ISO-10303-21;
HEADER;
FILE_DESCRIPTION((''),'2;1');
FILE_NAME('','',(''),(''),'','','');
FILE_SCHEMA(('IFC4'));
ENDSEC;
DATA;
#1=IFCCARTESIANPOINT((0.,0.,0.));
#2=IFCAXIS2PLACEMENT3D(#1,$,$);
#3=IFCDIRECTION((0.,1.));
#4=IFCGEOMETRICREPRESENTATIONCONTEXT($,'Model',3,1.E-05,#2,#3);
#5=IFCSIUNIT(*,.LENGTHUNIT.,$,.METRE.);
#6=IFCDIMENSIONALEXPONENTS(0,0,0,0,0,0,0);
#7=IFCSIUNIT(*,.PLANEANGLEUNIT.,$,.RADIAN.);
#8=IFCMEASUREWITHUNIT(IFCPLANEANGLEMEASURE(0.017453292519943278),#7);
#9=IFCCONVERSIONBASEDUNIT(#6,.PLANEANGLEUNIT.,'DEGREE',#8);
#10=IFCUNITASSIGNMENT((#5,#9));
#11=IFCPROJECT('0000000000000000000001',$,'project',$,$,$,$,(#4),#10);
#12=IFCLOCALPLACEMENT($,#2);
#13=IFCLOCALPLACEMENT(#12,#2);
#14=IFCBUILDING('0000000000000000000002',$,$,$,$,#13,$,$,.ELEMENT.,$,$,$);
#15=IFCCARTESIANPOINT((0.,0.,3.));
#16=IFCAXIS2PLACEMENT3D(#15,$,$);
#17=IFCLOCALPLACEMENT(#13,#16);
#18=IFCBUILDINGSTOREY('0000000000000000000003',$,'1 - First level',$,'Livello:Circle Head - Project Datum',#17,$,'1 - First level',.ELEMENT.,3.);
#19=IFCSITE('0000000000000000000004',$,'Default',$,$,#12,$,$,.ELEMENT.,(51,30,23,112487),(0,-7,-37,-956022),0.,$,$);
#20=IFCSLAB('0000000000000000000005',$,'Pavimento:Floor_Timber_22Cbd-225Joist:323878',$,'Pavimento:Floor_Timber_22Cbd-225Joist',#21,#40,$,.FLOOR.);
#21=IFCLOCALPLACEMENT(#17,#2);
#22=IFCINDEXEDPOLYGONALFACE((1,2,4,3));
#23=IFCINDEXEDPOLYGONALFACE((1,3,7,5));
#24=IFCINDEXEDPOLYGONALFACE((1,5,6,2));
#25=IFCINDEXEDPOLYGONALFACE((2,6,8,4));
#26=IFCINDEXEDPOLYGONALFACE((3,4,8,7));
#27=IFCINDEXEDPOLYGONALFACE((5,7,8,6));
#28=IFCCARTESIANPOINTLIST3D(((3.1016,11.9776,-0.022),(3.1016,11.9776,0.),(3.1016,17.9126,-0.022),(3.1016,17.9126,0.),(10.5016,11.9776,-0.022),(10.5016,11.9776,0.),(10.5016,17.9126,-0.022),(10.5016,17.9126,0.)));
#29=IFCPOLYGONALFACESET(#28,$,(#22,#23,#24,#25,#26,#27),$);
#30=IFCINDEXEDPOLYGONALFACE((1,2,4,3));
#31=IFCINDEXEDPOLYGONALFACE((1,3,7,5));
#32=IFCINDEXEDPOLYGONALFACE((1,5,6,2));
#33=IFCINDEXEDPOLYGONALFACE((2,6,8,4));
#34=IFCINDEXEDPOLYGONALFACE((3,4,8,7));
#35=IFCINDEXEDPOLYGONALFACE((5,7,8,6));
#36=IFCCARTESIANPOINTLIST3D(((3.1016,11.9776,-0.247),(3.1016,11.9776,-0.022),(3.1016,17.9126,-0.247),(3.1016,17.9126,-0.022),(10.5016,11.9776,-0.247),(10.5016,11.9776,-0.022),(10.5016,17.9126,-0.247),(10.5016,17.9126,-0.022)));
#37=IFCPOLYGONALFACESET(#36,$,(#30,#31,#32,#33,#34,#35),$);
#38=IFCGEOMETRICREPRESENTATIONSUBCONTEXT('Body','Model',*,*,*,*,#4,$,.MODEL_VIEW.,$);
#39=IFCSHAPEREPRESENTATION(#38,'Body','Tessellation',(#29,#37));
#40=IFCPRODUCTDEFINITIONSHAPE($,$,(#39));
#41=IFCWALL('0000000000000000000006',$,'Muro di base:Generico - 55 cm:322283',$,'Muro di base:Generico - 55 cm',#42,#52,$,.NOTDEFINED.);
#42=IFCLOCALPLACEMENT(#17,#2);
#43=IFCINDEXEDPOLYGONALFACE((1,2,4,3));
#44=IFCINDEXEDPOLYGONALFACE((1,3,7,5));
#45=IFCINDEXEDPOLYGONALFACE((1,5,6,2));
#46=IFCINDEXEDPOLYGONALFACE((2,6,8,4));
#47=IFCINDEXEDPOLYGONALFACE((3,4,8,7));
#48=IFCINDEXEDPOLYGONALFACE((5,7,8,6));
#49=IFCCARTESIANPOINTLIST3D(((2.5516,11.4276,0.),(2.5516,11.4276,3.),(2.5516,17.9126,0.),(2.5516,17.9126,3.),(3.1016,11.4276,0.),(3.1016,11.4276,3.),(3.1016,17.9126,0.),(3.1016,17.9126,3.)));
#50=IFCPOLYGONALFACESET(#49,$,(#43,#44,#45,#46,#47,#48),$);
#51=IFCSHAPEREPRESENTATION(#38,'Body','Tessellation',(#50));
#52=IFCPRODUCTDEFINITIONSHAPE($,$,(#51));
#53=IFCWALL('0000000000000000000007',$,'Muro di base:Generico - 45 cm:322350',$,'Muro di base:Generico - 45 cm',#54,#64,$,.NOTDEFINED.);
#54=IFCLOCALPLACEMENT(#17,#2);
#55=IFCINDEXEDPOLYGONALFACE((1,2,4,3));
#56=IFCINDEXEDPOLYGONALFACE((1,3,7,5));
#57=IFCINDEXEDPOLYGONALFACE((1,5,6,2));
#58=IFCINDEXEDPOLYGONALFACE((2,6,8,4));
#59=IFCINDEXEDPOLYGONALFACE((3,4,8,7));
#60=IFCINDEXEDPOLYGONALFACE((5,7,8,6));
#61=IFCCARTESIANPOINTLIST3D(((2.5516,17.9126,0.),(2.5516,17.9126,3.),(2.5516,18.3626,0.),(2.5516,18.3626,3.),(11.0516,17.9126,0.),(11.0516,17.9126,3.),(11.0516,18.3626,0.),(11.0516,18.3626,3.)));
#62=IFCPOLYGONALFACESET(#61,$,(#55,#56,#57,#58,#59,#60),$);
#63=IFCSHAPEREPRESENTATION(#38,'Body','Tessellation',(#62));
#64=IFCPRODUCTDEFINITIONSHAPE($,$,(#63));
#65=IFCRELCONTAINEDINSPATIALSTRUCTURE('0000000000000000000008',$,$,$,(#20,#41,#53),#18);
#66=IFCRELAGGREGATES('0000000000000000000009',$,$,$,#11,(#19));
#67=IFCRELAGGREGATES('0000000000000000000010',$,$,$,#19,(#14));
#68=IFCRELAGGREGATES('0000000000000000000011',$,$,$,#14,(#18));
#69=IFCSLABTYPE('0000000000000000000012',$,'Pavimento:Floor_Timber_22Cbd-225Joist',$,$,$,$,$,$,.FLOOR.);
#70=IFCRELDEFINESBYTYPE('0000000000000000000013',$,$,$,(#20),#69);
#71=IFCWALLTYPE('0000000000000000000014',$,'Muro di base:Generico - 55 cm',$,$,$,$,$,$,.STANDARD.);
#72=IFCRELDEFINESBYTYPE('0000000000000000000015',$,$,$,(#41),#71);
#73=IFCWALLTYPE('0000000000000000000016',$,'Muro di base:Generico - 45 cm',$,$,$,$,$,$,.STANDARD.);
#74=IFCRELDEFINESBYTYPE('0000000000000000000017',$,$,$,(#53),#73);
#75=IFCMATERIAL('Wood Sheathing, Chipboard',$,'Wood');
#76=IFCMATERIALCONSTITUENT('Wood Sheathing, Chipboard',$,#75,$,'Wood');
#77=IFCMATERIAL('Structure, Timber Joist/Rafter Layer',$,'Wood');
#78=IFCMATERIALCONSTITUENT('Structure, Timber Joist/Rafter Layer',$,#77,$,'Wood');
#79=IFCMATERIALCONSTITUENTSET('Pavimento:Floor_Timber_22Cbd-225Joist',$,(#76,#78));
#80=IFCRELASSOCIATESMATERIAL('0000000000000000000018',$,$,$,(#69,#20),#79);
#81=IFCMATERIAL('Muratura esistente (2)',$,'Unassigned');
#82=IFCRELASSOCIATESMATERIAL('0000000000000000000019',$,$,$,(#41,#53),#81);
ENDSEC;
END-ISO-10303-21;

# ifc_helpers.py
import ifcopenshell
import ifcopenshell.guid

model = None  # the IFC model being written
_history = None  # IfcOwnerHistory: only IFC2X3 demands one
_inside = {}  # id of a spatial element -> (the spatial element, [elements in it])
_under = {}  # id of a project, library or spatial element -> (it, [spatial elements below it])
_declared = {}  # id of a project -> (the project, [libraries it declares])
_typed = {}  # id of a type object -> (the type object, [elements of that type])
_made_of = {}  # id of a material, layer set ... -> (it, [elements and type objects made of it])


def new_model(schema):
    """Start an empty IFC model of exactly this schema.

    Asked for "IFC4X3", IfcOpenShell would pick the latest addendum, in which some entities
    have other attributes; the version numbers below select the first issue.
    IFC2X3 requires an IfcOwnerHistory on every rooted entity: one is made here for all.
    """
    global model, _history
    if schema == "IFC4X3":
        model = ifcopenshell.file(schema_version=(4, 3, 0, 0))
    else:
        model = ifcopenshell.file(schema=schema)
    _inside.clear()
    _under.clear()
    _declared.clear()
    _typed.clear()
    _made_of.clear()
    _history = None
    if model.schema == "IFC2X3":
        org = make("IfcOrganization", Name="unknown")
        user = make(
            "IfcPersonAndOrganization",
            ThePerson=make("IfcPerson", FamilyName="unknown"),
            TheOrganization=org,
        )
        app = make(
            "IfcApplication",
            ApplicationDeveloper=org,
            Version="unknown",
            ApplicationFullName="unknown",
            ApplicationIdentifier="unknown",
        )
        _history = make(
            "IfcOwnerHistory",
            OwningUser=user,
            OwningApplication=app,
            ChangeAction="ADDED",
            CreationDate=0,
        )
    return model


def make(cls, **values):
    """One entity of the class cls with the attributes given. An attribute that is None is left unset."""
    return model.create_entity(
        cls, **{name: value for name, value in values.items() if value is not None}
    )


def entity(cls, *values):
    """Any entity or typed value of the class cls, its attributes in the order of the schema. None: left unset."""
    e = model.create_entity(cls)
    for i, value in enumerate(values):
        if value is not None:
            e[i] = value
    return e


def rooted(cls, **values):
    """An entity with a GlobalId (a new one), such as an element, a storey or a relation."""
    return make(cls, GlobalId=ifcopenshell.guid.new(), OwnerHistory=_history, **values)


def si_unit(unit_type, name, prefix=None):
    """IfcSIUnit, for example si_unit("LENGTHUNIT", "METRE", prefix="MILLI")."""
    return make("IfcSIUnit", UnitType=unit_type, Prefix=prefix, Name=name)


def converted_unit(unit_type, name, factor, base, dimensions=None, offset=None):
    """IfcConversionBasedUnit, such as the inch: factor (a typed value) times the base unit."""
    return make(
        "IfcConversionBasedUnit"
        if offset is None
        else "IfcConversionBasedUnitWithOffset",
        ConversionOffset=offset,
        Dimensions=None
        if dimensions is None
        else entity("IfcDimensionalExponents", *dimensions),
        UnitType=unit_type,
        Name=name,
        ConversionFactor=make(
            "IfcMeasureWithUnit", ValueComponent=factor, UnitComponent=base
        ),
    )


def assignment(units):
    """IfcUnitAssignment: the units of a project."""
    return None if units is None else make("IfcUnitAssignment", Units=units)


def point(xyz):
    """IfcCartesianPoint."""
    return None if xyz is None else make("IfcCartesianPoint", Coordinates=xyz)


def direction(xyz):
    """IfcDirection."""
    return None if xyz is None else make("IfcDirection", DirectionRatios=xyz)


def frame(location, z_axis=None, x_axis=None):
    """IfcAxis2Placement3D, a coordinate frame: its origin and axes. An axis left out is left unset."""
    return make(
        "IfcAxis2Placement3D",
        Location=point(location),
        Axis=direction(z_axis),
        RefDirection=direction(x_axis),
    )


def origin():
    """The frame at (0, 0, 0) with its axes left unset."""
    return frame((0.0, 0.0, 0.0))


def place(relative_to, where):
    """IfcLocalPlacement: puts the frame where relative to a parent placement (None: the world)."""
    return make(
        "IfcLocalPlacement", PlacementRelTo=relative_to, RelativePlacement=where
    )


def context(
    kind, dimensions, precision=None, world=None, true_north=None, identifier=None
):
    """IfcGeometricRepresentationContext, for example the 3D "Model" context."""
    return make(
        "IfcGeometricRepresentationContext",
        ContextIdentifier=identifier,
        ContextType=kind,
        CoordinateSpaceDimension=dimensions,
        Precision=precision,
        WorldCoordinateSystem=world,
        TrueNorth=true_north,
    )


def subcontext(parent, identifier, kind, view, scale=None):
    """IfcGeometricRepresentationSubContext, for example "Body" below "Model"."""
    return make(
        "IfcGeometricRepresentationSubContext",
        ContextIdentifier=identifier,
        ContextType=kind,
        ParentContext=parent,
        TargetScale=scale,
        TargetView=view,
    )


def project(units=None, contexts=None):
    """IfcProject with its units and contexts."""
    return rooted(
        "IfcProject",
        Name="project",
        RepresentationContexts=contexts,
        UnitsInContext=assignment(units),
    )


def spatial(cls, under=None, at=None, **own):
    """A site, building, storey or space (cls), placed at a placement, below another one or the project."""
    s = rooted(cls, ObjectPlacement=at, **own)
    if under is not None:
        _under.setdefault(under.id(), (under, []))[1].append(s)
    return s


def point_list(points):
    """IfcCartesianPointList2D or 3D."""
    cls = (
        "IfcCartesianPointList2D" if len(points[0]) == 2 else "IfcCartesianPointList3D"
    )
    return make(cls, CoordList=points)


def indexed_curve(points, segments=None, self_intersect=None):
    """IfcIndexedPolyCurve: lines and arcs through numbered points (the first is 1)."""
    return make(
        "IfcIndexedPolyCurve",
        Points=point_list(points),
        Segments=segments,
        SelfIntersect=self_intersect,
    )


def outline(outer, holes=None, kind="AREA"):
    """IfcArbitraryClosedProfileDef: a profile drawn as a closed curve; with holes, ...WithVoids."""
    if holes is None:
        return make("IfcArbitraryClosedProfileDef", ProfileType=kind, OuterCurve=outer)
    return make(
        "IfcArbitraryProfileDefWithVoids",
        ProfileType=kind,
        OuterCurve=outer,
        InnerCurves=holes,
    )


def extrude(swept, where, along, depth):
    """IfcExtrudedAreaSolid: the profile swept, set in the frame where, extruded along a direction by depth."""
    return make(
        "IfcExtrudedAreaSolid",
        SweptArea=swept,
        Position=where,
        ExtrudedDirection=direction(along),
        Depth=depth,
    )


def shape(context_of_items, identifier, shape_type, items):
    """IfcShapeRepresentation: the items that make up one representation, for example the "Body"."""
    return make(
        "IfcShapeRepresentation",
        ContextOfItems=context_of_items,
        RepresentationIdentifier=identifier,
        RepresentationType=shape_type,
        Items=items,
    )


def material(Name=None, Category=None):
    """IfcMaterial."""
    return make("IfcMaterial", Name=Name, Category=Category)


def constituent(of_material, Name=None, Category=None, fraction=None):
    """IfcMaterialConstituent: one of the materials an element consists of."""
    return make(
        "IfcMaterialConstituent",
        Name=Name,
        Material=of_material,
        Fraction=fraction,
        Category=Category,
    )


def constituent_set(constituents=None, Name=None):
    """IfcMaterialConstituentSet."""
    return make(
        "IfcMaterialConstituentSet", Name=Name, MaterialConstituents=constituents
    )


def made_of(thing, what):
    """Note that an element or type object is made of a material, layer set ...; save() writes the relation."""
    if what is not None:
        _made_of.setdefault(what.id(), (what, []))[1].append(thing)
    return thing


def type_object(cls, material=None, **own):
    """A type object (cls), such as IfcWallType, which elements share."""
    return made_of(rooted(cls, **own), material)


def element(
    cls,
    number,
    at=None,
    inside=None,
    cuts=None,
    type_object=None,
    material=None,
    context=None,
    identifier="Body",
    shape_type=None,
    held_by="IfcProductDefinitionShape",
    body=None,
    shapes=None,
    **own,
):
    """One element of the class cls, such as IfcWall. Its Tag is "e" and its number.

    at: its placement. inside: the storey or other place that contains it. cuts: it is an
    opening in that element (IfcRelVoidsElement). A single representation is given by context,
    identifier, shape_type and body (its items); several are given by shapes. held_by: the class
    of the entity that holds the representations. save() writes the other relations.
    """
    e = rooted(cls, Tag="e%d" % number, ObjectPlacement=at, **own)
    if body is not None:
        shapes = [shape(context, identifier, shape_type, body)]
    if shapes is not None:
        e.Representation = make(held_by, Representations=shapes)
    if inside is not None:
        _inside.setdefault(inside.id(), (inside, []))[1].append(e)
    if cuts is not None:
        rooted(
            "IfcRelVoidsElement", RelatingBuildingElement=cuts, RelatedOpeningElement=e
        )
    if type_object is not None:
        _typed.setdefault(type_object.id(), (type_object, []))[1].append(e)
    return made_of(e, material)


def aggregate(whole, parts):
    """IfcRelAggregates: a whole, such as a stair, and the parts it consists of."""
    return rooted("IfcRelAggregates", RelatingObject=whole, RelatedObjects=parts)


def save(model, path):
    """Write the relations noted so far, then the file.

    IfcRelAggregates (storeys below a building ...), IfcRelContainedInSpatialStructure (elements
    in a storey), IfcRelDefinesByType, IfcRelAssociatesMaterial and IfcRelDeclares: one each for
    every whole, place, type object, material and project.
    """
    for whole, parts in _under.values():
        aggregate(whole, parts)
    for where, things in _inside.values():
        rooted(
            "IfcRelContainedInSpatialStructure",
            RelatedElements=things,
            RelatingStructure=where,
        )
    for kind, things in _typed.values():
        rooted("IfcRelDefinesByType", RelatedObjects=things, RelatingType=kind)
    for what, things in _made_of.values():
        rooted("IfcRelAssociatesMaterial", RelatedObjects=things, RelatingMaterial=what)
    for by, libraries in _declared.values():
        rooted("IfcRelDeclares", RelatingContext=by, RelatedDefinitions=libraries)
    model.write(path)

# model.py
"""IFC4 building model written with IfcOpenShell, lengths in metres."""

from ifc_helpers import new_model, entity, si_unit, converted_unit, direction, frame, origin, place, context, subcontext, project, spatial, indexed_curve, outline, extrude, material, constituent, constituent_set, type_object, element, save


model = new_model("IFC4")

# Units and contexts
model_context = context("Model", 3, precision=1e-05, world=origin(), true_north=direction((0.0, 1.0)))
body_context = subcontext(model_context, "Body", "Model", "MODEL_VIEW")
ifc_project = project(units=[si_unit("LENGTHUNIT", "METRE"), converted_unit("PLANEANGLEUNIT", "DEGREE", entity("IfcPlaneAngleMeasure", 0.017453292519943278), si_unit("PLANEANGLEUNIT", "RADIAN"), dimensions=[0, 0, 0, 0, 0, 0, 0])], contexts=[model_context])

# Site, building, storey
site_placement = place(None, origin())
site = spatial("IfcSite", under=ifc_project, at=site_placement, Name="Default", CompositionType="ELEMENT", RefLatitude=(51, 30, 23, 112487), RefLongitude=(0, -7, -37, -956022), RefElevation=0.0)
building_placement = place(site_placement, origin())
building = spatial("IfcBuilding", under=site, at=building_placement, CompositionType="ELEMENT")
storey_placement = place(building_placement, frame((0.0, 0.0, 3.0)))
storey = spatial("IfcBuildingStorey", under=building, at=storey_placement, Name="1 - First level", ObjectType="Livello:Circle Head - Project Datum", LongName="1 - First level", CompositionType="ELEMENT", Elevation=3.0)

# Slab
ifc_material_1 = material(Name="Wood Sheathing, Chipboard", Category="Wood")
ifc_constituent_1 = constituent(ifc_material_1, Name="Wood Sheathing, Chipboard", Category="Wood")
ifc_material_2 = material(Name="Structure, Timber Joist/Rafter Layer", Category="Wood")
ifc_constituent_2 = constituent(ifc_material_2, Name="Structure, Timber Joist/Rafter Layer", Category="Wood")
ifc_constituent_set = constituent_set(constituents=[ifc_constituent_1, ifc_constituent_2], Name="Pavimento:Floor_Timber_22Cbd-225Joist")
slab_type = type_object("IfcSlabType", Name="Pavimento:Floor_Timber_22Cbd-225Joist", PredefinedType="FLOOR", material=ifc_constituent_set)
slab_placement = place(storey_placement, origin())
element("IfcSlab", 1, at=slab_placement, inside=storey, type_object=slab_type, material=ifc_constituent_set, Name="Pavimento:Floor_Timber_22Cbd-225Joist:323878", ObjectType="Pavimento:Floor_Timber_22Cbd-225Joist", PredefinedType="FLOOR", context=body_context, shape_type="SweptSolid", body=[
    extrude(outline(indexed_curve([(-3.7, -2.9675), (3.7, -2.9675), (3.7, 2.9675), (-3.7, 2.9675), (-3.7, -2.9675)], self_intersect=False)), frame((6.8016, 14.9451, -0.022)), (0.0, 0.0, 1.0), 0.022),
    extrude(outline(indexed_curve([(-3.7, -2.9675), (3.7, -2.9675), (3.7, 2.9675), (-3.7, 2.9675), (-3.7, -2.9675)], self_intersect=False)), frame((6.8016, 14.9451, -0.247)), (0.0, 0.0, 1.0), 0.225),
])

# Walls
ifc_material_3 = material(Name="Muratura esistente (2)", Category="Unassigned")
wall_type_1 = type_object("IfcWallType", Name="Muro di base:Generico - 55 cm", PredefinedType="STANDARD")
wall_1_placement = place(storey_placement, frame((2.8266, 17.9126, 0.0), z_axis=(0.0, 0.0, 1.0), x_axis=(0.0, -1.0, 0.0)))
element("IfcWall", 2, at=wall_1_placement, inside=storey, type_object=wall_type_1, material=ifc_material_3, Name="Muro di base:Generico - 55 cm:322283", ObjectType="Muro di base:Generico - 55 cm", PredefinedType="NOTDEFINED", context=body_context, shape_type="SweptSolid", body=[
    extrude(outline(indexed_curve([(6.485, 0.275), (0.0, 0.275), (0.0, -0.275), (6.485, -0.275), (6.485, 0.275)], self_intersect=False)), origin(), (0.0, 0.0, 1.0), 3.0),
])
wall_type_2 = type_object("IfcWallType", Name="Muro di base:Generico - 45 cm", PredefinedType="STANDARD")
wall_2_placement = place(storey_placement, frame((2.5516, 18.1376, 0.0)))
element("IfcWall", 3, at=wall_2_placement, inside=storey, type_object=wall_type_2, material=ifc_material_3, Name="Muro di base:Generico - 45 cm:322350", ObjectType="Muro di base:Generico - 45 cm", PredefinedType="NOTDEFINED", context=body_context, shape_type="SweptSolid", body=[
    extrude(outline(indexed_curve([(8.5, 0.225), (0.0, 0.225), (0.0, -0.225), (8.5, -0.225), (8.5, 0.225)], self_intersect=False)), origin(), (0.0, 0.0, 1.0), 3.0),
])

save(model, "model.ifc")
